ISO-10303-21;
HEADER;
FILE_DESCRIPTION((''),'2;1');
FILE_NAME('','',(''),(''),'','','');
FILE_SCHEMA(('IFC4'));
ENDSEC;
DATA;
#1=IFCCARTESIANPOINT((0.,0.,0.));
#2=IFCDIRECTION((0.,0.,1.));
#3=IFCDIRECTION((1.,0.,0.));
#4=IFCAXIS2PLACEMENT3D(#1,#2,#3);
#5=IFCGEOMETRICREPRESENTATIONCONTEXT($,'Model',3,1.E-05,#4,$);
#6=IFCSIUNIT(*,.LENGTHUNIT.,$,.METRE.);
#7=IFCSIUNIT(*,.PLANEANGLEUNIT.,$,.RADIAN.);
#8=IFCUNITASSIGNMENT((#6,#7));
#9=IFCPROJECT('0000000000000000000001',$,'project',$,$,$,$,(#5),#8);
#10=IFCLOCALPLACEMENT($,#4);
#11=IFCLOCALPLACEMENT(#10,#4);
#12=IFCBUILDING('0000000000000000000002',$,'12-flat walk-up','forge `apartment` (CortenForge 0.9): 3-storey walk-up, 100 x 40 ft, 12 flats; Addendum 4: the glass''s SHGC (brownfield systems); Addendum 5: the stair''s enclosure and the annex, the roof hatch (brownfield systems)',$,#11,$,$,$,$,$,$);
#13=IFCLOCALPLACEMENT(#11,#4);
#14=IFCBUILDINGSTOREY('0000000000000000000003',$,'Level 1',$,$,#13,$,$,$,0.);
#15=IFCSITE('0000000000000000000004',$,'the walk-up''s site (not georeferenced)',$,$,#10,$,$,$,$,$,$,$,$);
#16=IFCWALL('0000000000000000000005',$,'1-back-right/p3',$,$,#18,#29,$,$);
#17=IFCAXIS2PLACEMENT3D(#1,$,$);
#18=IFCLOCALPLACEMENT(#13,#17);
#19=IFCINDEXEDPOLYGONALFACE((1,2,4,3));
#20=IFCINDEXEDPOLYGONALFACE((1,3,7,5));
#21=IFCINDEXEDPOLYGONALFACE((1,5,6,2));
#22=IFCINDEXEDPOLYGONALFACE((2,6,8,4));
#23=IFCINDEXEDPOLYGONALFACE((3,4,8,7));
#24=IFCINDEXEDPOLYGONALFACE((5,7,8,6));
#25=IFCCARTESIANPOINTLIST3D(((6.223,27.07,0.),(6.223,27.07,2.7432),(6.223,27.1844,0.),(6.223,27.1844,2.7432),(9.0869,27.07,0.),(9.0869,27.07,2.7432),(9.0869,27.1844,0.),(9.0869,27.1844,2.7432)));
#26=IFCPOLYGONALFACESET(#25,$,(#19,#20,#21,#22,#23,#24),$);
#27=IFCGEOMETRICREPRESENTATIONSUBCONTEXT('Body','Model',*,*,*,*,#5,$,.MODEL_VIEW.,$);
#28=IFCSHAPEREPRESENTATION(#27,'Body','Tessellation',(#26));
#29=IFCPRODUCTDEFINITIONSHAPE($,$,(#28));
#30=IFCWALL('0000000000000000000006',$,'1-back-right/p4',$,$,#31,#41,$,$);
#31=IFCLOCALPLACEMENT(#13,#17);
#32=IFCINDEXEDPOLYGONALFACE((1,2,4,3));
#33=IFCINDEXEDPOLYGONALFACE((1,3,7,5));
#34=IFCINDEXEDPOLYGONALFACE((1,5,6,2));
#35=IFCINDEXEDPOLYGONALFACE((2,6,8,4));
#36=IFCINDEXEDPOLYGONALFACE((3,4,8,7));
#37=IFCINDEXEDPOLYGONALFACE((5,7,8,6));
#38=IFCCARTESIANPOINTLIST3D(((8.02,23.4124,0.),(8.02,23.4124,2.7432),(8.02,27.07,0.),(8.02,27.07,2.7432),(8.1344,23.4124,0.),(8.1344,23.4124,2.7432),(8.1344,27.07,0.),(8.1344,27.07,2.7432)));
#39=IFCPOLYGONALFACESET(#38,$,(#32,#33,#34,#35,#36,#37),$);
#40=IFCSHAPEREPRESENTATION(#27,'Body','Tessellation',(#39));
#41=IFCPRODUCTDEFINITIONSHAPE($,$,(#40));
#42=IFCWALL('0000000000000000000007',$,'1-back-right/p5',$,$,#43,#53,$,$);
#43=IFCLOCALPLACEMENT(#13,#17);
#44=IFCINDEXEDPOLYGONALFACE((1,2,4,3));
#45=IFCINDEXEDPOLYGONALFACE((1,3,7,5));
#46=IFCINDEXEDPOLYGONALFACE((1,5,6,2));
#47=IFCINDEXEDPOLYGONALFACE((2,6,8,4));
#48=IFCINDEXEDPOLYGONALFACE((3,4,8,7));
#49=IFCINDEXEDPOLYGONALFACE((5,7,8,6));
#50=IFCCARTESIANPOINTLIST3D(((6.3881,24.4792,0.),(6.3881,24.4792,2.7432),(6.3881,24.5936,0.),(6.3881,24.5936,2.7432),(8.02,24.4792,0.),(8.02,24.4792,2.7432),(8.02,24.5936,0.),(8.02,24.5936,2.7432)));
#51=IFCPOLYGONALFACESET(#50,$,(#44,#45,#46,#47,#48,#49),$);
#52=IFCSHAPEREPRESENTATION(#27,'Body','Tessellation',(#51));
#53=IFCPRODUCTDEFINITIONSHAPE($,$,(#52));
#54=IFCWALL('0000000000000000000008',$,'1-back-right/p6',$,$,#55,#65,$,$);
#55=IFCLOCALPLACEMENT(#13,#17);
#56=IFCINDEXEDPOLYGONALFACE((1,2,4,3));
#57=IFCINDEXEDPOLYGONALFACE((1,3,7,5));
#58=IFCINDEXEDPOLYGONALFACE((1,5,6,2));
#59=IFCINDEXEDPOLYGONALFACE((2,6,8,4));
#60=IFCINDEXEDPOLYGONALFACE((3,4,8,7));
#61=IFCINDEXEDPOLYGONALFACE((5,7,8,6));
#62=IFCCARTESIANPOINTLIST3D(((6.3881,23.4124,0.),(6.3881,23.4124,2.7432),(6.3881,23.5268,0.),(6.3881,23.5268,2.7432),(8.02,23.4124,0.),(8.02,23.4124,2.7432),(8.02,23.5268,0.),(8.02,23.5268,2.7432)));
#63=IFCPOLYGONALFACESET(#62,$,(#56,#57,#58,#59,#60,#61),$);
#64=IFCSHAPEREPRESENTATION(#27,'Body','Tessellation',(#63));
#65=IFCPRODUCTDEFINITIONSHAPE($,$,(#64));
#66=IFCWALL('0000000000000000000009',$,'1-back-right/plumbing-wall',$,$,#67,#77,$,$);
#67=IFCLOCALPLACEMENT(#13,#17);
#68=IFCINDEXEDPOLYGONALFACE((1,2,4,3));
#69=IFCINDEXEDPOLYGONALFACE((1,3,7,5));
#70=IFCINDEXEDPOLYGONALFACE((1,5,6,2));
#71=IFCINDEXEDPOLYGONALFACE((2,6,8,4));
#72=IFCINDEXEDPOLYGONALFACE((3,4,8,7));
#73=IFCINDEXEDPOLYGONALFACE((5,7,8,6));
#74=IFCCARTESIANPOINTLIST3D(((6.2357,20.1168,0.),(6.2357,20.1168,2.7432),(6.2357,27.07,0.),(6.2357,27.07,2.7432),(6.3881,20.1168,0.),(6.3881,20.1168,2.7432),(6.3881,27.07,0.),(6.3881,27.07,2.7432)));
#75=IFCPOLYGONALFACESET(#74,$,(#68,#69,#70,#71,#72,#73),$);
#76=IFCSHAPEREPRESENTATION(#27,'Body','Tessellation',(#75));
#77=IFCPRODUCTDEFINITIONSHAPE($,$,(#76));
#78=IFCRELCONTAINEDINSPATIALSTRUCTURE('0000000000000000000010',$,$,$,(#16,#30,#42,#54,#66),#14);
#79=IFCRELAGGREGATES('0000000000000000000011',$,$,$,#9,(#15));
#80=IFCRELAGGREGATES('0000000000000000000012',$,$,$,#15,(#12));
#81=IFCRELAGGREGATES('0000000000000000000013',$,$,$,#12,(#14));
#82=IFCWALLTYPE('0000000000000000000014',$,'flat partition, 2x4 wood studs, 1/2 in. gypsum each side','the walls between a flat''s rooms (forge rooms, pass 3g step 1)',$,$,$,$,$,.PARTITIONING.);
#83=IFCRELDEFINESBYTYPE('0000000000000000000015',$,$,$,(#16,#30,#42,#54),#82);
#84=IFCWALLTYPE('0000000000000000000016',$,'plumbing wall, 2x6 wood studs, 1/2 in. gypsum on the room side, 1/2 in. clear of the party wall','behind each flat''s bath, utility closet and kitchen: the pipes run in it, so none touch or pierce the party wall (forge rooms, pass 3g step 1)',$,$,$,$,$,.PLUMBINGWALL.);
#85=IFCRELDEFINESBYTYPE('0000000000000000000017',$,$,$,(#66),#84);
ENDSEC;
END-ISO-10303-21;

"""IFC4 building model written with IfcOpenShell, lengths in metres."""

from ifc_helpers import new_model, si_unit, frame, frame_2d, origin, origin_with_axes, place, context, subcontext, project, spatial, rectangle, extrude, type_object, element, save


model = new_model("IFC4")

# Units and contexts
model_context = context("Model", 3, precision=1e-05, world=origin_with_axes())
body_context = subcontext(model_context, "Body", "Model", "MODEL_VIEW")
ifc_project = project(units=[si_unit("LENGTHUNIT", "METRE"), si_unit("PLANEANGLEUNIT", "RADIAN")], contexts=[model_context])

# Site, building, storey
site_placement = place(None, origin_with_axes())
site = spatial("IfcSite", under=ifc_project, at=site_placement, Name="the walk-up's site (not georeferenced)")
building_placement = place(site_placement, origin_with_axes())
building = spatial("IfcBuilding", under=site, at=building_placement, Name="12-flat walk-up", Description="forge `apartment` (CortenForge 0.9): 3-storey walk-up, 100 x 40 ft, 12 flats; Addendum 4: the glass's SHGC (brownfield systems); Addendum 5: the stair's enclosure and the annex, the roof hatch (brownfield systems)")
storey_placement = place(building_placement, origin_with_axes())
storey = spatial("IfcBuildingStorey", under=building, at=storey_placement, Name="Level 1", Elevation=0.0)

# Walls
wall_type_1 = type_object("IfcWallType", Name="flat partition, 2x4 wood studs, 1/2 in. gypsum each side", Description="the walls between a flat's rooms (forge rooms, pass 3g step 1)", PredefinedType="PARTITIONING")
wall_1_placement = place(storey_placement, frame((6.223, 27.07, 0.0), z_axis=(0.0, 0.0, 1.0), x_axis=(1.0, 0.0, 0.0)))
element("IfcWall", 1, at=wall_1_placement, inside=storey, type_object=wall_type_1, Name="1-back-right/p3", context=body_context, shape_type="SweptSolid", body=[
    extrude(rectangle(XDim=2.8639, YDim=0.1143, at=frame_2d((1.4319, 0.0572))), origin(), (0.0, 0.0, 1.0), 2.7432),
])
wall_2_placement = place(storey_placement, frame((8.02, 23.4124, 0.0), z_axis=(0.0, 0.0, 1.0), x_axis=(1.0, 0.0, 0.0)))
element("IfcWall", 2, at=wall_2_placement, inside=storey, type_object=wall_type_1, Name="1-back-right/p4", context=body_context, shape_type="SweptSolid", body=[
    extrude(rectangle(XDim=0.1143, YDim=3.6576, at=frame_2d((0.0572, 1.8288))), origin(), (0.0, 0.0, 1.0), 2.7432),
])
for number, where, z_axis, x_axis, name in (
    (3, (6.3881, 24.4793, 0.0), (0.0, 0.0, 1.0), (1.0, 0.0, 0.0), "1-back-right/p5"),
    (4, (6.3881, 23.4124, 0.0), (0.0, 0.0, 1.0), (1.0, 0.0, 0.0), "1-back-right/p6"),
):
    element("IfcWall", number, at=place(storey_placement, frame(where, z_axis=z_axis, x_axis=x_axis)), inside=storey, type_object=wall_type_1, Name=name, context=body_context, shape_type="SweptSolid", body=[
        extrude(rectangle(XDim=1.6319, YDim=0.1143, at=frame_2d((0.816, 0.0572))), origin(), (0.0, 0.0, 1.0), 2.7432),
    ])
wall_type_2 = type_object("IfcWallType", Name="plumbing wall, 2x6 wood studs, 1/2 in. gypsum on the room side, 1/2 in. clear of the party wall", Description="behind each flat's bath, utility closet and kitchen: the pipes run in it, so none touch or pierce the party wall (forge rooms, pass 3g step 1)", PredefinedType="PLUMBINGWALL")
wall_3_placement = place(storey_placement, frame((6.2357, 20.1168, 0.0), z_axis=(0.0, 0.0, 1.0), x_axis=(1.0, 0.0, 0.0)))
element("IfcWall", 5, at=wall_3_placement, inside=storey, type_object=wall_type_2, Name="1-back-right/plumbing-wall", context=body_context, shape_type="SweptSolid", body=[
    extrude(rectangle(XDim=0.1524, YDim=6.9532, at=frame_2d((0.0762, 3.4766))), origin(), (0.0, 0.0, 1.0), 2.7432),
])

save(model, "model.ifc")
